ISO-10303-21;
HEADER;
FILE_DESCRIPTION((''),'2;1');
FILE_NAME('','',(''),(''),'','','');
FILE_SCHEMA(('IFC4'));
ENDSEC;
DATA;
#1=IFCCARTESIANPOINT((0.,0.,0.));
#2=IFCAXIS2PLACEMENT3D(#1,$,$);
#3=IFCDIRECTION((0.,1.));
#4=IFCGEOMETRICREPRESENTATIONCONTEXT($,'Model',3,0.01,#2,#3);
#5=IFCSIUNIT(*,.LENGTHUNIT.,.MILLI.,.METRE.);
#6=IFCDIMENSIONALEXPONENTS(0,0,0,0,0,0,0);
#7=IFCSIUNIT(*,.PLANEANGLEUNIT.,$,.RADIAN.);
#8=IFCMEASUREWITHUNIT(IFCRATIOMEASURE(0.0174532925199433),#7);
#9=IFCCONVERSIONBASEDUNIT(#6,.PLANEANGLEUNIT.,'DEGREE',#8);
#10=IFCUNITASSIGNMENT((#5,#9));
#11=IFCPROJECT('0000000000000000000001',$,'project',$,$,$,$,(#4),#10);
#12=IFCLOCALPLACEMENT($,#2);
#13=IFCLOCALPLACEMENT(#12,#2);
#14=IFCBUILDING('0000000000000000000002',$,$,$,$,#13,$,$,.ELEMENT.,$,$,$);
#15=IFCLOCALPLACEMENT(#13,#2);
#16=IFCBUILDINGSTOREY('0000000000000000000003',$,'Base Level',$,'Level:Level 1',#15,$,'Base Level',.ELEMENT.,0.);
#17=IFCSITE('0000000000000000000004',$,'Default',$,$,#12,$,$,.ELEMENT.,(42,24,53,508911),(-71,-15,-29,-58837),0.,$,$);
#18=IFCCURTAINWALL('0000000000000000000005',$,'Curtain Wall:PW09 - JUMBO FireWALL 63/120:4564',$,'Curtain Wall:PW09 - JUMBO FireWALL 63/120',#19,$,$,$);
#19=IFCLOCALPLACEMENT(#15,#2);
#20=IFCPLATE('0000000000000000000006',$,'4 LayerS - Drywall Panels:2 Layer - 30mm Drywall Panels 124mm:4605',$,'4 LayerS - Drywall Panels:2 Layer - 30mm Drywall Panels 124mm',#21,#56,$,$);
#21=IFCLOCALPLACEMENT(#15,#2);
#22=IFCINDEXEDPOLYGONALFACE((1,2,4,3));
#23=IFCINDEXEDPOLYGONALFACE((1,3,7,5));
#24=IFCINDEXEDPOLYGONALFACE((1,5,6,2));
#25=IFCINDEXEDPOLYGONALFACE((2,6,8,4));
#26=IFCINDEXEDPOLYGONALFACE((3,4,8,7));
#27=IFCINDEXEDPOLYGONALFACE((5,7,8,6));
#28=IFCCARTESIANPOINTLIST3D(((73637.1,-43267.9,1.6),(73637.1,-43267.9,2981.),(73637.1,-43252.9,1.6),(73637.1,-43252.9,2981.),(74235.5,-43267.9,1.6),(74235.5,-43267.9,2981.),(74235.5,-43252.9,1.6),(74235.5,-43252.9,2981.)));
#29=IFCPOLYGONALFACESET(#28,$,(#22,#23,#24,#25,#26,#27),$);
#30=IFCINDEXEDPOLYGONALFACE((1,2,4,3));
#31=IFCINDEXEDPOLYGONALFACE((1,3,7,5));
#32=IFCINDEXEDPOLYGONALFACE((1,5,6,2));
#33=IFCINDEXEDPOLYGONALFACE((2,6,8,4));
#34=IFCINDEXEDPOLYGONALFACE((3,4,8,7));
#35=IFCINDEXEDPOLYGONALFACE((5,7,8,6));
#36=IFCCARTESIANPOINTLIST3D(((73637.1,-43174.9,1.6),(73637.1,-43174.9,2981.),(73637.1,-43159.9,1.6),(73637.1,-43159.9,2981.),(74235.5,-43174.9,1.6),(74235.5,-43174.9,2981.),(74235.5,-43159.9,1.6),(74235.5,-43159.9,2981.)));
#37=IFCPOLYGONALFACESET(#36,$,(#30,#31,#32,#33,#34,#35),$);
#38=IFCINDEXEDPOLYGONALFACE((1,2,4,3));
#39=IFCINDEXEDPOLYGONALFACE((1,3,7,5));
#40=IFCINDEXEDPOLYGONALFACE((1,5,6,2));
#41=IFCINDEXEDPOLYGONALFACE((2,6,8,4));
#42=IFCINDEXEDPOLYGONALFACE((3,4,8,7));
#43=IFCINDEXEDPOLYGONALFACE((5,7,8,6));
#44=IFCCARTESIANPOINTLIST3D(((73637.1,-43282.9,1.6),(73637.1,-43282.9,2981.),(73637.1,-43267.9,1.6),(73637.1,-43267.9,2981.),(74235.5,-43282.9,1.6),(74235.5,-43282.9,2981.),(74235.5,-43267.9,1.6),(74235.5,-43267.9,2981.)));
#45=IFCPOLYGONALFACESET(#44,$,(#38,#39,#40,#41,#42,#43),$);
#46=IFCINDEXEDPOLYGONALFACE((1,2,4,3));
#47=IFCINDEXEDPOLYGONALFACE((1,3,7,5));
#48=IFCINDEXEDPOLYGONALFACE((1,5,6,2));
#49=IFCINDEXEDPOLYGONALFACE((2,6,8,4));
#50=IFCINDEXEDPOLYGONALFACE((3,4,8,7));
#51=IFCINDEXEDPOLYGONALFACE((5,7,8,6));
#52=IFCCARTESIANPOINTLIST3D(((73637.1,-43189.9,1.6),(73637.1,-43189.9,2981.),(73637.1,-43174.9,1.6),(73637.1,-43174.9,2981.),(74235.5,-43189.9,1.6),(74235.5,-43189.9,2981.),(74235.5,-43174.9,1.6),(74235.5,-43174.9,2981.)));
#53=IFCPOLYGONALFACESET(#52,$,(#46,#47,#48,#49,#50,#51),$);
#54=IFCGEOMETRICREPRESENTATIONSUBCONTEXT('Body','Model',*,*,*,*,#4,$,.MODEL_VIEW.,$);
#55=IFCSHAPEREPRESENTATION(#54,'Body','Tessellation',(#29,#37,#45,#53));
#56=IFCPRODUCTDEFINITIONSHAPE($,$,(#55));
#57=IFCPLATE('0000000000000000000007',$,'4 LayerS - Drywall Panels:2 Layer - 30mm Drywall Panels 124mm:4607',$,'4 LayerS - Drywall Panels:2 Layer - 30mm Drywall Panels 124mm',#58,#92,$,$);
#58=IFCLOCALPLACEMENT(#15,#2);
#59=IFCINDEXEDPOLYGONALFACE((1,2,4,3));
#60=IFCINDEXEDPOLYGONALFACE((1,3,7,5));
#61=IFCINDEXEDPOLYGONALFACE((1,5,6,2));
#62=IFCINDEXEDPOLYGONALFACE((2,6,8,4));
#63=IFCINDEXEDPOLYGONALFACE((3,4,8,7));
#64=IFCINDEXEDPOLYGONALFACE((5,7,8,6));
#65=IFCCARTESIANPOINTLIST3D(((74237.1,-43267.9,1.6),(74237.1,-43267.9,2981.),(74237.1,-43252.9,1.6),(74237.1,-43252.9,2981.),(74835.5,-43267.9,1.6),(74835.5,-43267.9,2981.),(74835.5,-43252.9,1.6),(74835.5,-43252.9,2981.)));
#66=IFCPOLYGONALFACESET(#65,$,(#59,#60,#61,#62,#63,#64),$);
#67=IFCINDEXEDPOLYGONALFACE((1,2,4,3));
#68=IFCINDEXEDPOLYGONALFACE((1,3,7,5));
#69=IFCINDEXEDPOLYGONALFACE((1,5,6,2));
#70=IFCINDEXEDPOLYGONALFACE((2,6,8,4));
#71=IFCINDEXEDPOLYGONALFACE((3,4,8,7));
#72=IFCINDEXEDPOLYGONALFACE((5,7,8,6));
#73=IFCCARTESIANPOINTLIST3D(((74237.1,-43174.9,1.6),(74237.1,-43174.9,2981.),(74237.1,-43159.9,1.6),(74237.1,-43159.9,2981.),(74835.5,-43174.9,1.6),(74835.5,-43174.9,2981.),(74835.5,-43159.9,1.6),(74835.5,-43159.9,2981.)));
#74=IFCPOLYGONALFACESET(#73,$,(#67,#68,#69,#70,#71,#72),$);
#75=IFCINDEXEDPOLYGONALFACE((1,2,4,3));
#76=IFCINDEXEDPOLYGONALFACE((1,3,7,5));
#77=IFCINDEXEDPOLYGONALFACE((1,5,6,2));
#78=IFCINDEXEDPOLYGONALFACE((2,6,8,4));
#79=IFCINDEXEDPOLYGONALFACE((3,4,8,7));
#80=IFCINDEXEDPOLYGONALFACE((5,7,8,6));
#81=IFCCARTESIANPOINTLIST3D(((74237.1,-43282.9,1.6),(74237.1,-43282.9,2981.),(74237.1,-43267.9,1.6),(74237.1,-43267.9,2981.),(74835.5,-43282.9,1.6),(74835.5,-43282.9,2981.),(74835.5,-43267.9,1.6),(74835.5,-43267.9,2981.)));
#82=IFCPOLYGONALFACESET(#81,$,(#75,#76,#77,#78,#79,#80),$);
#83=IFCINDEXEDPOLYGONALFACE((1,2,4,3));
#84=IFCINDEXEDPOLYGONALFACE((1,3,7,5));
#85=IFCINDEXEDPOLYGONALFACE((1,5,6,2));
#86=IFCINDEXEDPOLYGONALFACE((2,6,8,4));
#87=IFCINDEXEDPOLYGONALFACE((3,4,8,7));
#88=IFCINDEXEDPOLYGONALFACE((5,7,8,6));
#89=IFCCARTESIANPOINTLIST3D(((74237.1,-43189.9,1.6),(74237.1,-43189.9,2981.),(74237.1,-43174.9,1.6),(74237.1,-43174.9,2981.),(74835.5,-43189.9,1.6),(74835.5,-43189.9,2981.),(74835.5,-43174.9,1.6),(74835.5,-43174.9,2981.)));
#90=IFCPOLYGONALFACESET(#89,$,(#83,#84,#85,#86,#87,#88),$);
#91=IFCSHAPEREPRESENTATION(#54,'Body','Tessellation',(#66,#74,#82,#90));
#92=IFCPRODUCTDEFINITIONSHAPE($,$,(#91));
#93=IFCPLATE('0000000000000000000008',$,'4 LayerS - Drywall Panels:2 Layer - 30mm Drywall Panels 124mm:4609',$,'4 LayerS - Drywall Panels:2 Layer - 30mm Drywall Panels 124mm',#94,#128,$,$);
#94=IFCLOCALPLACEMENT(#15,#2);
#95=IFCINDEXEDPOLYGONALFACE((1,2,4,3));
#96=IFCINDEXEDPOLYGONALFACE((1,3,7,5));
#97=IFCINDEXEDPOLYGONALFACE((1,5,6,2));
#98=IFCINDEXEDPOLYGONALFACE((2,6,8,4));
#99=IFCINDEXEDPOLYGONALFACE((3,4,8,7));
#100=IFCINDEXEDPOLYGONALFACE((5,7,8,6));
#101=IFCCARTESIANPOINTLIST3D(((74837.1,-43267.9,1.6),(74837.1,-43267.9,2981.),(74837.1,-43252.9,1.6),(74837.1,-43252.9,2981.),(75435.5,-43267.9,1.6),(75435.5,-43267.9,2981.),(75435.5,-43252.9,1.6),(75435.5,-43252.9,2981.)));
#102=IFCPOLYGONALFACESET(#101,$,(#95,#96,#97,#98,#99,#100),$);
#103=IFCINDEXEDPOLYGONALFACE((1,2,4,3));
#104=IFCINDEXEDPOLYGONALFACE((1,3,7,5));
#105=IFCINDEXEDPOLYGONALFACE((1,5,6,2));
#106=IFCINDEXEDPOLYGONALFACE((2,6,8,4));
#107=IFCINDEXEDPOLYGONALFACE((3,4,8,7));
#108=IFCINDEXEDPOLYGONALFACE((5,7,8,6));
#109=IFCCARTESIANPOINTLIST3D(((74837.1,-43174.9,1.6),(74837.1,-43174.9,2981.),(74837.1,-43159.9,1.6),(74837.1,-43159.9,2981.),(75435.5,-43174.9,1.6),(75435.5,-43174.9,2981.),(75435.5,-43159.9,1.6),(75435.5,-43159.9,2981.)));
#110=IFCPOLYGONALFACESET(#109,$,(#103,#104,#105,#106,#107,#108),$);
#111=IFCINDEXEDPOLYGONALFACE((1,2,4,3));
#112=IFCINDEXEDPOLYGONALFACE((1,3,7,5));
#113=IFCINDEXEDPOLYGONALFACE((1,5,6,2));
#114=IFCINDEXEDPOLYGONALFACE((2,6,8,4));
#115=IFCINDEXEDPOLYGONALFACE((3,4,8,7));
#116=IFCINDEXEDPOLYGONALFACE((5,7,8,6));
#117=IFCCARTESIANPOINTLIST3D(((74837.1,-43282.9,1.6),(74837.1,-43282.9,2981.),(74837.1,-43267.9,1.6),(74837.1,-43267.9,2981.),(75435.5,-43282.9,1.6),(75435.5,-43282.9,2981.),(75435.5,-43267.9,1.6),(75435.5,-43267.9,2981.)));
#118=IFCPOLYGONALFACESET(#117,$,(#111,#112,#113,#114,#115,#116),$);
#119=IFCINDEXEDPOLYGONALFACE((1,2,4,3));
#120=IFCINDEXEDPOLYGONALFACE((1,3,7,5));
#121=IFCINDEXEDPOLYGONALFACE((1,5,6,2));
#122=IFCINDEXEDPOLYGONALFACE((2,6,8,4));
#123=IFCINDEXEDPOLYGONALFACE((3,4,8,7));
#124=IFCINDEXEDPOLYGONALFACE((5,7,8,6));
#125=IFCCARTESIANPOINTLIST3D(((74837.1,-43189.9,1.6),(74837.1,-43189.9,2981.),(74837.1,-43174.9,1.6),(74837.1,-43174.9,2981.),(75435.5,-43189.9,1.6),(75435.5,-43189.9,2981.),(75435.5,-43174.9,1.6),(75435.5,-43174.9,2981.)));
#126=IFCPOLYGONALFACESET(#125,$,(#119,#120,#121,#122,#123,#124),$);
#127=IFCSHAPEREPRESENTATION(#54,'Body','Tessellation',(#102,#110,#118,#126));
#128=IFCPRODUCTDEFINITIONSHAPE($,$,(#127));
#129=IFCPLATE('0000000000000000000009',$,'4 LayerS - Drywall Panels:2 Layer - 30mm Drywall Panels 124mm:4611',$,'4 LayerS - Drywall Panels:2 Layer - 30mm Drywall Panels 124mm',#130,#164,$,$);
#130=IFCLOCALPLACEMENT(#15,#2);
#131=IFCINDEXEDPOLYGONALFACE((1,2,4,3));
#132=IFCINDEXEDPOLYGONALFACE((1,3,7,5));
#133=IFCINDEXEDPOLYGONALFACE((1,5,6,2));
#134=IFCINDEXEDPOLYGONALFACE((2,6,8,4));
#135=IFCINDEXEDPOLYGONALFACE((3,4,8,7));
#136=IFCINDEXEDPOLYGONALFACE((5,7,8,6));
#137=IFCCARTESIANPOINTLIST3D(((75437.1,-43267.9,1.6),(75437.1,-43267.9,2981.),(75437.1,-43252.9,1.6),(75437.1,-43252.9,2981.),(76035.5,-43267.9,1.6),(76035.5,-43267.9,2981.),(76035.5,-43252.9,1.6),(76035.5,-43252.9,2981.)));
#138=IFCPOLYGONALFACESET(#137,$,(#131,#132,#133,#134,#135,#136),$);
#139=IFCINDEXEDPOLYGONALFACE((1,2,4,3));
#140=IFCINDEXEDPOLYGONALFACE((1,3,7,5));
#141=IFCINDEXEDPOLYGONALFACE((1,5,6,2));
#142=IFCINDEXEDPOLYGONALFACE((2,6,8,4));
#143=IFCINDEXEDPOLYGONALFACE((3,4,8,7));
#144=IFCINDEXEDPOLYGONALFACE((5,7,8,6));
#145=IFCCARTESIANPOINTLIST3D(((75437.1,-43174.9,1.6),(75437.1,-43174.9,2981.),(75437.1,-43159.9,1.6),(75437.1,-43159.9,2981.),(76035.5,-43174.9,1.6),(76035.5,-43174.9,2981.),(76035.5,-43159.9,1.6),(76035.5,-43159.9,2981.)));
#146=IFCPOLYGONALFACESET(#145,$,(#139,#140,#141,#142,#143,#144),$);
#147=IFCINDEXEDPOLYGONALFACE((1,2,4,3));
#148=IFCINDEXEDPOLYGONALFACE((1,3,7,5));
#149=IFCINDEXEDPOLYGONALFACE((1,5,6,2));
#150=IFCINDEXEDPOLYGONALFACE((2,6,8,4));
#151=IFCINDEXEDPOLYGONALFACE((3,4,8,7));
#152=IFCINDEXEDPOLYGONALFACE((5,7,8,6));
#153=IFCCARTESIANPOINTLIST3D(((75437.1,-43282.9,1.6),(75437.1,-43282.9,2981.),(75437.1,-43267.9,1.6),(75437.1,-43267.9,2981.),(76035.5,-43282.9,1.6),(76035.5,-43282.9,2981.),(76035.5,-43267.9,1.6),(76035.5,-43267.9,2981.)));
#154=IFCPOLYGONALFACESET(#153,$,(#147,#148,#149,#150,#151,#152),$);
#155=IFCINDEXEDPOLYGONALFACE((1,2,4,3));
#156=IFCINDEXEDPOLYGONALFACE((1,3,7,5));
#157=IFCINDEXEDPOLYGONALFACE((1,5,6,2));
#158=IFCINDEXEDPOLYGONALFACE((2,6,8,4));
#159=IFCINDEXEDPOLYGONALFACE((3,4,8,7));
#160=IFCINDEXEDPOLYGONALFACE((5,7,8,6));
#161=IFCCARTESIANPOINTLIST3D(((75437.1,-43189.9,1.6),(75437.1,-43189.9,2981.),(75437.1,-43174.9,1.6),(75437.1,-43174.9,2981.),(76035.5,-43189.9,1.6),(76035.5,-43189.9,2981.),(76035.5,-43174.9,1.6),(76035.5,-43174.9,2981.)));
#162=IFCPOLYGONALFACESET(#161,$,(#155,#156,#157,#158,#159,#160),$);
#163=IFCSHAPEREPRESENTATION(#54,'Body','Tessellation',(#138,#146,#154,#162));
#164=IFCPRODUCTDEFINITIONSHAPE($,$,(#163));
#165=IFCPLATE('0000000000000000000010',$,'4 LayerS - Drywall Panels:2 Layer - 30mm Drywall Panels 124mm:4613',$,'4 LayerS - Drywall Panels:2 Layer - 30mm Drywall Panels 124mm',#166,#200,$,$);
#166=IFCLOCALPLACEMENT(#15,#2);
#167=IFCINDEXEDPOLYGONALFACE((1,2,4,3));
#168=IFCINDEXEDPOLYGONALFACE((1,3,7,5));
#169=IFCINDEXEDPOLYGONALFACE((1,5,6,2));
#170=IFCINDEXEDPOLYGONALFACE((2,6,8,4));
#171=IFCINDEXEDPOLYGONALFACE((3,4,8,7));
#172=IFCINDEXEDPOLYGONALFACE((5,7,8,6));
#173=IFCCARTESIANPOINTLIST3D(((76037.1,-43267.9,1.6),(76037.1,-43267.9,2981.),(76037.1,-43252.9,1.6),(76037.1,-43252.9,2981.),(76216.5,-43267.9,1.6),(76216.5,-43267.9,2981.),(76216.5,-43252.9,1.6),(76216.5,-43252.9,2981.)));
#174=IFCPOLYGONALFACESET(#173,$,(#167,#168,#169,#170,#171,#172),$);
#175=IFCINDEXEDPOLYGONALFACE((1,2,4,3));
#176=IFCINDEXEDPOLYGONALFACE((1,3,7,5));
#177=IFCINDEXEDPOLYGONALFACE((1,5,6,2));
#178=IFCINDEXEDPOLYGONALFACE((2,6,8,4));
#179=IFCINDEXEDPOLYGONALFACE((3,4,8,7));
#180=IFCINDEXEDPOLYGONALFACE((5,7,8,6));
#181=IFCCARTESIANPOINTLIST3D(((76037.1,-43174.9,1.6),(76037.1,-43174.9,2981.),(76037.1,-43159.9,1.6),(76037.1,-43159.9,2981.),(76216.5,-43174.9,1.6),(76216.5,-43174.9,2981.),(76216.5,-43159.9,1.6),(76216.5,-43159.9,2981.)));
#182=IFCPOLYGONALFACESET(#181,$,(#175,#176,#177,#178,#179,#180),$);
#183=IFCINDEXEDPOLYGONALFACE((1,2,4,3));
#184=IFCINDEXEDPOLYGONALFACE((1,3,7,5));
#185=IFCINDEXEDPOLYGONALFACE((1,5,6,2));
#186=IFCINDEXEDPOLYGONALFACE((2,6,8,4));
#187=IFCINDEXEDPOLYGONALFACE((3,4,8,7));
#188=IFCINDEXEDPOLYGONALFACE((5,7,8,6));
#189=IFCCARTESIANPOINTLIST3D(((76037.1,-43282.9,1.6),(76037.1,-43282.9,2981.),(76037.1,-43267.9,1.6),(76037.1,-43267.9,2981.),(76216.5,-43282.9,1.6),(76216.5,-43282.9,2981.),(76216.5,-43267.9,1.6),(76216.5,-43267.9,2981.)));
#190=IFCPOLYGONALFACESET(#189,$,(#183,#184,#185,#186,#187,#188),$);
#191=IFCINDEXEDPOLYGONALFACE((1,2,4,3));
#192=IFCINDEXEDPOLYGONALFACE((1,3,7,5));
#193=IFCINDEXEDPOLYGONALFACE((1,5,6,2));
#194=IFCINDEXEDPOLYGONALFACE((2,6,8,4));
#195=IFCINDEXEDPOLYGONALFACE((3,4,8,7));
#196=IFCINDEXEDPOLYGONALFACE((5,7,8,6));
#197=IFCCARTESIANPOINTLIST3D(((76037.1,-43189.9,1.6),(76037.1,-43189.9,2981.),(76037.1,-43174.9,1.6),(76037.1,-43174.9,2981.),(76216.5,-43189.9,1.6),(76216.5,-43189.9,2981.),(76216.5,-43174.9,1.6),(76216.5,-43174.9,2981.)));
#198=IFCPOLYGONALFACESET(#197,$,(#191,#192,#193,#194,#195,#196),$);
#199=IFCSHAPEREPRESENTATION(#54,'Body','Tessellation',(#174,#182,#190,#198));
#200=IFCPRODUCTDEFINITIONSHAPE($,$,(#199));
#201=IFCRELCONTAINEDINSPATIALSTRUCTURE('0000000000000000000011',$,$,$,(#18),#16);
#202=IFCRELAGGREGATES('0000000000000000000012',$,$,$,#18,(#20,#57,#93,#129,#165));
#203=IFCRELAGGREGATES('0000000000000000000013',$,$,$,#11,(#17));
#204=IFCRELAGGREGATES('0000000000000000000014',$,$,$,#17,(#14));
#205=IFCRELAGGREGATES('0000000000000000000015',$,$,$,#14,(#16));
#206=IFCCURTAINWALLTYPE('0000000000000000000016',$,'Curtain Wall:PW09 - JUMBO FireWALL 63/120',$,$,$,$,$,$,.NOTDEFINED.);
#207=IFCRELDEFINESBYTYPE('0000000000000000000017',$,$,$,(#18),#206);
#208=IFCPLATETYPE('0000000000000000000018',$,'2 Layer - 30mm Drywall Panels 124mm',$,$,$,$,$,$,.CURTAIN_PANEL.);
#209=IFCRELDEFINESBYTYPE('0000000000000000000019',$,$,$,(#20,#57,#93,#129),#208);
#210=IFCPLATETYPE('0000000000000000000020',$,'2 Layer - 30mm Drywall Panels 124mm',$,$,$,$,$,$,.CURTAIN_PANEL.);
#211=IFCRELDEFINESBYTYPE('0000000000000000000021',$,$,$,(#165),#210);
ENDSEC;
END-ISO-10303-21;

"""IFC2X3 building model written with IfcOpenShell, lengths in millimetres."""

from ifc_helpers import new_model, entity, si_unit, converted_unit, direction, frame, frame_2d, origin, origin_2d_with_axis, place, context, subcontext, project, spatial, rectangle, extrude, source, transform, mapped, type_object, type_shapes, element, aggregate, save


model = new_model("IFC2X3")

# Units and contexts
model_context = context("Model", 3, precision=0.01, world=origin(), true_north=direction((0.0, 1.0)))
body_context = subcontext(model_context, "Body", "Model", "MODEL_VIEW")
ifc_project = project(units=[si_unit("LENGTHUNIT", "METRE", prefix="MILLI"), converted_unit("PLANEANGLEUNIT", "DEGREE", entity("IfcRatioMeasure", 0.0174532925199433), si_unit("PLANEANGLEUNIT", "RADIAN"), dimensions=[0, 0, 0, 0, 0, 0, 0])], contexts=[model_context])

# Site, building, storey
site_placement = place(None, origin())
site = spatial("IfcSite", under=ifc_project, at=site_placement, Name="Default", CompositionType="ELEMENT", RefLatitude=(42, 24, 53, 508911), RefLongitude=(-71, -15, -29, -58837), RefElevation=0.0)
building_placement = place(site_placement, origin())
building = spatial("IfcBuilding", under=site, at=building_placement, CompositionType="ELEMENT")
storey_placement = place(building_placement, origin())
storey = spatial("IfcBuildingStorey", under=building, at=storey_placement, Name="Base Level", ObjectType="Level:Level 1", LongName="Base Level", CompositionType="ELEMENT", Elevation=0.0)

# Curtain wall, plates
curtain_wall_type = type_object("IfcCurtainWallType", Name="Curtain Wall:PW09 - JUMBO FireWALL 63/120", PredefinedType="NOTDEFINED")
curtain_wall_placement = place(building_placement, origin())
curtain_wall = element("IfcCurtainWall", 1, at=curtain_wall_placement, inside=storey, type_object=curtain_wall_type, Name="Curtain Wall:PW09 - JUMBO FireWALL 63/120:4564", ObjectType="Curtain Wall:PW09 - JUMBO FireWALL 63/120")
plate_type_1 = type_object("IfcPlateType", Name="2 Layer - 30mm Drywall Panels 124mm", PredefinedType="CURTAIN_PANEL")
shared_shape_1 = source(origin(), body_context, "Body", "SweptSolid", [
    extrude(rectangle(XDim=15.0, YDim=598.4, at=origin_2d_with_axis()), frame((0.0, -39.0, 0.0), z_axis=(0.0, 0.0, 1.0), x_axis=(0.0, 1.0, 0.0)), (0.0, 0.0, 1.0), 2979.4),
    extrude(rectangle(XDim=15.0, YDim=598.4, at=origin_2d_with_axis()), frame((0.0, 54.0, 0.0), z_axis=(0.0, 0.0, 1.0), x_axis=(0.0, 1.0, 0.0)), (0.0, 0.0, 1.0), 2979.4),
    extrude(rectangle(XDim=598.4, YDim=15.0, at=frame_2d((0.0, 0.0), x_axis=(1.0, 0.0))), frame((0.0, -54.0, 0.0), z_axis=(0.0, 0.0, 1.0), x_axis=(-1.0, 0.0, 0.0)), (0.0, 0.0, 1.0), 2979.4),
    extrude(rectangle(XDim=15.0, YDim=598.4, at=frame_2d((0.0, 0.0), x_axis=(1.0, 0.0))), frame((0.0, 39.0, 0.0), z_axis=(0.0, 0.0, 1.0), x_axis=(0.0, 1.0, 0.0)), (0.0, 0.0, 1.0), 2979.4),
])
type_shapes(plate_type_1, [shared_shape_1])
plate_1_placement = place(curtain_wall_placement, frame((73936.3, -43221.4, 1.6)))
plate_1 = element("IfcPlate", 2, at=plate_1_placement, type_object=plate_type_1, Name="4 LayerS - Drywall Panels:2 Layer - 30mm Drywall Panels 124mm:4605", ObjectType="4 LayerS - Drywall Panels:2 Layer - 30mm Drywall Panels 124mm", context=body_context, shape_type="MappedRepresentation", body=[
    mapped(shared_shape_1, transform((0.0, 0.0, 0.0), scale=1.0)),
])
plate_2_placement = place(curtain_wall_placement, frame((74536.3, -43221.4, 1.6)))
plate_2 = element("IfcPlate", 3, at=plate_2_placement, type_object=plate_type_1, Name="4 LayerS - Drywall Panels:2 Layer - 30mm Drywall Panels 124mm:4607", ObjectType="4 LayerS - Drywall Panels:2 Layer - 30mm Drywall Panels 124mm", context=body_context, shape_type="MappedRepresentation", body=[
    mapped(shared_shape_1, transform((0.0, 0.0, 0.0), scale=1.0)),
])
plate_3_placement = place(curtain_wall_placement, frame((75136.3, -43221.4, 1.6)))
plate_3 = element("IfcPlate", 4, at=plate_3_placement, type_object=plate_type_1, Name="4 LayerS - Drywall Panels:2 Layer - 30mm Drywall Panels 124mm:4609", ObjectType="4 LayerS - Drywall Panels:2 Layer - 30mm Drywall Panels 124mm", context=body_context, shape_type="MappedRepresentation", body=[
    mapped(shared_shape_1, transform((0.0, 0.0, 0.0), scale=1.0)),
])
plate_4_placement = place(curtain_wall_placement, frame((75736.3, -43221.4, 1.6)))
plate_4 = element("IfcPlate", 5, at=plate_4_placement, type_object=plate_type_1, Name="4 LayerS - Drywall Panels:2 Layer - 30mm Drywall Panels 124mm:4611", ObjectType="4 LayerS - Drywall Panels:2 Layer - 30mm Drywall Panels 124mm", context=body_context, shape_type="MappedRepresentation", body=[
    mapped(shared_shape_1, transform((0.0, 0.0, 0.0), scale=1.0)),
])
plate_type_2 = type_object("IfcPlateType", Name="2 Layer - 30mm Drywall Panels 124mm", PredefinedType="CURTAIN_PANEL")
shared_shape_2 = source(origin(), body_context, "Body", "SweptSolid", [
    extrude(rectangle(XDim=15.0, YDim=179.4, at=origin_2d_with_axis()), frame((0.0, -39.0, 0.0), z_axis=(0.0, 0.0, 1.0), x_axis=(0.0, 1.0, 0.0)), (0.0, 0.0, 1.0), 2979.4),
    extrude(rectangle(XDim=15.0, YDim=179.4, at=origin_2d_with_axis()), frame((0.0, 54.0, 0.0), z_axis=(0.0, 0.0, 1.0), x_axis=(0.0, 1.0, 0.0)), (0.0, 0.0, 1.0), 2979.4),
    extrude(rectangle(XDim=179.4, YDim=15.0, at=frame_2d((0.0, 0.0), x_axis=(1.0, 0.0))), frame((0.0, -54.0, 0.0), z_axis=(0.0, 0.0, 1.0), x_axis=(-1.0, 0.0, 0.0)), (0.0, 0.0, 1.0), 2979.4),
    extrude(rectangle(XDim=15.0, YDim=179.4, at=frame_2d((0.0, 0.0), x_axis=(1.0, 0.0))), frame((0.0, 39.0, 0.0), z_axis=(0.0, 0.0, 1.0), x_axis=(0.0, 1.0, 0.0)), (0.0, 0.0, 1.0), 2979.4),
])
type_shapes(plate_type_2, [shared_shape_2])
plate_5_placement = place(curtain_wall_placement, frame((76126.8, -43221.4, 1.6)))
plate_5 = element("IfcPlate", 6, at=plate_5_placement, type_object=plate_type_2, Name="4 LayerS - Drywall Panels:2 Layer - 30mm Drywall Panels 124mm:4613", ObjectType="4 LayerS - Drywall Panels:2 Layer - 30mm Drywall Panels 124mm", context=body_context, shape_type="MappedRepresentation", body=[
    mapped(shared_shape_2, transform((0.0, 0.0, 0.0), scale=1.0)),
])
aggregate(curtain_wall, [plate_1, plate_2, plate_3, plate_4, plate_5])

save(model, "model.ifc")
